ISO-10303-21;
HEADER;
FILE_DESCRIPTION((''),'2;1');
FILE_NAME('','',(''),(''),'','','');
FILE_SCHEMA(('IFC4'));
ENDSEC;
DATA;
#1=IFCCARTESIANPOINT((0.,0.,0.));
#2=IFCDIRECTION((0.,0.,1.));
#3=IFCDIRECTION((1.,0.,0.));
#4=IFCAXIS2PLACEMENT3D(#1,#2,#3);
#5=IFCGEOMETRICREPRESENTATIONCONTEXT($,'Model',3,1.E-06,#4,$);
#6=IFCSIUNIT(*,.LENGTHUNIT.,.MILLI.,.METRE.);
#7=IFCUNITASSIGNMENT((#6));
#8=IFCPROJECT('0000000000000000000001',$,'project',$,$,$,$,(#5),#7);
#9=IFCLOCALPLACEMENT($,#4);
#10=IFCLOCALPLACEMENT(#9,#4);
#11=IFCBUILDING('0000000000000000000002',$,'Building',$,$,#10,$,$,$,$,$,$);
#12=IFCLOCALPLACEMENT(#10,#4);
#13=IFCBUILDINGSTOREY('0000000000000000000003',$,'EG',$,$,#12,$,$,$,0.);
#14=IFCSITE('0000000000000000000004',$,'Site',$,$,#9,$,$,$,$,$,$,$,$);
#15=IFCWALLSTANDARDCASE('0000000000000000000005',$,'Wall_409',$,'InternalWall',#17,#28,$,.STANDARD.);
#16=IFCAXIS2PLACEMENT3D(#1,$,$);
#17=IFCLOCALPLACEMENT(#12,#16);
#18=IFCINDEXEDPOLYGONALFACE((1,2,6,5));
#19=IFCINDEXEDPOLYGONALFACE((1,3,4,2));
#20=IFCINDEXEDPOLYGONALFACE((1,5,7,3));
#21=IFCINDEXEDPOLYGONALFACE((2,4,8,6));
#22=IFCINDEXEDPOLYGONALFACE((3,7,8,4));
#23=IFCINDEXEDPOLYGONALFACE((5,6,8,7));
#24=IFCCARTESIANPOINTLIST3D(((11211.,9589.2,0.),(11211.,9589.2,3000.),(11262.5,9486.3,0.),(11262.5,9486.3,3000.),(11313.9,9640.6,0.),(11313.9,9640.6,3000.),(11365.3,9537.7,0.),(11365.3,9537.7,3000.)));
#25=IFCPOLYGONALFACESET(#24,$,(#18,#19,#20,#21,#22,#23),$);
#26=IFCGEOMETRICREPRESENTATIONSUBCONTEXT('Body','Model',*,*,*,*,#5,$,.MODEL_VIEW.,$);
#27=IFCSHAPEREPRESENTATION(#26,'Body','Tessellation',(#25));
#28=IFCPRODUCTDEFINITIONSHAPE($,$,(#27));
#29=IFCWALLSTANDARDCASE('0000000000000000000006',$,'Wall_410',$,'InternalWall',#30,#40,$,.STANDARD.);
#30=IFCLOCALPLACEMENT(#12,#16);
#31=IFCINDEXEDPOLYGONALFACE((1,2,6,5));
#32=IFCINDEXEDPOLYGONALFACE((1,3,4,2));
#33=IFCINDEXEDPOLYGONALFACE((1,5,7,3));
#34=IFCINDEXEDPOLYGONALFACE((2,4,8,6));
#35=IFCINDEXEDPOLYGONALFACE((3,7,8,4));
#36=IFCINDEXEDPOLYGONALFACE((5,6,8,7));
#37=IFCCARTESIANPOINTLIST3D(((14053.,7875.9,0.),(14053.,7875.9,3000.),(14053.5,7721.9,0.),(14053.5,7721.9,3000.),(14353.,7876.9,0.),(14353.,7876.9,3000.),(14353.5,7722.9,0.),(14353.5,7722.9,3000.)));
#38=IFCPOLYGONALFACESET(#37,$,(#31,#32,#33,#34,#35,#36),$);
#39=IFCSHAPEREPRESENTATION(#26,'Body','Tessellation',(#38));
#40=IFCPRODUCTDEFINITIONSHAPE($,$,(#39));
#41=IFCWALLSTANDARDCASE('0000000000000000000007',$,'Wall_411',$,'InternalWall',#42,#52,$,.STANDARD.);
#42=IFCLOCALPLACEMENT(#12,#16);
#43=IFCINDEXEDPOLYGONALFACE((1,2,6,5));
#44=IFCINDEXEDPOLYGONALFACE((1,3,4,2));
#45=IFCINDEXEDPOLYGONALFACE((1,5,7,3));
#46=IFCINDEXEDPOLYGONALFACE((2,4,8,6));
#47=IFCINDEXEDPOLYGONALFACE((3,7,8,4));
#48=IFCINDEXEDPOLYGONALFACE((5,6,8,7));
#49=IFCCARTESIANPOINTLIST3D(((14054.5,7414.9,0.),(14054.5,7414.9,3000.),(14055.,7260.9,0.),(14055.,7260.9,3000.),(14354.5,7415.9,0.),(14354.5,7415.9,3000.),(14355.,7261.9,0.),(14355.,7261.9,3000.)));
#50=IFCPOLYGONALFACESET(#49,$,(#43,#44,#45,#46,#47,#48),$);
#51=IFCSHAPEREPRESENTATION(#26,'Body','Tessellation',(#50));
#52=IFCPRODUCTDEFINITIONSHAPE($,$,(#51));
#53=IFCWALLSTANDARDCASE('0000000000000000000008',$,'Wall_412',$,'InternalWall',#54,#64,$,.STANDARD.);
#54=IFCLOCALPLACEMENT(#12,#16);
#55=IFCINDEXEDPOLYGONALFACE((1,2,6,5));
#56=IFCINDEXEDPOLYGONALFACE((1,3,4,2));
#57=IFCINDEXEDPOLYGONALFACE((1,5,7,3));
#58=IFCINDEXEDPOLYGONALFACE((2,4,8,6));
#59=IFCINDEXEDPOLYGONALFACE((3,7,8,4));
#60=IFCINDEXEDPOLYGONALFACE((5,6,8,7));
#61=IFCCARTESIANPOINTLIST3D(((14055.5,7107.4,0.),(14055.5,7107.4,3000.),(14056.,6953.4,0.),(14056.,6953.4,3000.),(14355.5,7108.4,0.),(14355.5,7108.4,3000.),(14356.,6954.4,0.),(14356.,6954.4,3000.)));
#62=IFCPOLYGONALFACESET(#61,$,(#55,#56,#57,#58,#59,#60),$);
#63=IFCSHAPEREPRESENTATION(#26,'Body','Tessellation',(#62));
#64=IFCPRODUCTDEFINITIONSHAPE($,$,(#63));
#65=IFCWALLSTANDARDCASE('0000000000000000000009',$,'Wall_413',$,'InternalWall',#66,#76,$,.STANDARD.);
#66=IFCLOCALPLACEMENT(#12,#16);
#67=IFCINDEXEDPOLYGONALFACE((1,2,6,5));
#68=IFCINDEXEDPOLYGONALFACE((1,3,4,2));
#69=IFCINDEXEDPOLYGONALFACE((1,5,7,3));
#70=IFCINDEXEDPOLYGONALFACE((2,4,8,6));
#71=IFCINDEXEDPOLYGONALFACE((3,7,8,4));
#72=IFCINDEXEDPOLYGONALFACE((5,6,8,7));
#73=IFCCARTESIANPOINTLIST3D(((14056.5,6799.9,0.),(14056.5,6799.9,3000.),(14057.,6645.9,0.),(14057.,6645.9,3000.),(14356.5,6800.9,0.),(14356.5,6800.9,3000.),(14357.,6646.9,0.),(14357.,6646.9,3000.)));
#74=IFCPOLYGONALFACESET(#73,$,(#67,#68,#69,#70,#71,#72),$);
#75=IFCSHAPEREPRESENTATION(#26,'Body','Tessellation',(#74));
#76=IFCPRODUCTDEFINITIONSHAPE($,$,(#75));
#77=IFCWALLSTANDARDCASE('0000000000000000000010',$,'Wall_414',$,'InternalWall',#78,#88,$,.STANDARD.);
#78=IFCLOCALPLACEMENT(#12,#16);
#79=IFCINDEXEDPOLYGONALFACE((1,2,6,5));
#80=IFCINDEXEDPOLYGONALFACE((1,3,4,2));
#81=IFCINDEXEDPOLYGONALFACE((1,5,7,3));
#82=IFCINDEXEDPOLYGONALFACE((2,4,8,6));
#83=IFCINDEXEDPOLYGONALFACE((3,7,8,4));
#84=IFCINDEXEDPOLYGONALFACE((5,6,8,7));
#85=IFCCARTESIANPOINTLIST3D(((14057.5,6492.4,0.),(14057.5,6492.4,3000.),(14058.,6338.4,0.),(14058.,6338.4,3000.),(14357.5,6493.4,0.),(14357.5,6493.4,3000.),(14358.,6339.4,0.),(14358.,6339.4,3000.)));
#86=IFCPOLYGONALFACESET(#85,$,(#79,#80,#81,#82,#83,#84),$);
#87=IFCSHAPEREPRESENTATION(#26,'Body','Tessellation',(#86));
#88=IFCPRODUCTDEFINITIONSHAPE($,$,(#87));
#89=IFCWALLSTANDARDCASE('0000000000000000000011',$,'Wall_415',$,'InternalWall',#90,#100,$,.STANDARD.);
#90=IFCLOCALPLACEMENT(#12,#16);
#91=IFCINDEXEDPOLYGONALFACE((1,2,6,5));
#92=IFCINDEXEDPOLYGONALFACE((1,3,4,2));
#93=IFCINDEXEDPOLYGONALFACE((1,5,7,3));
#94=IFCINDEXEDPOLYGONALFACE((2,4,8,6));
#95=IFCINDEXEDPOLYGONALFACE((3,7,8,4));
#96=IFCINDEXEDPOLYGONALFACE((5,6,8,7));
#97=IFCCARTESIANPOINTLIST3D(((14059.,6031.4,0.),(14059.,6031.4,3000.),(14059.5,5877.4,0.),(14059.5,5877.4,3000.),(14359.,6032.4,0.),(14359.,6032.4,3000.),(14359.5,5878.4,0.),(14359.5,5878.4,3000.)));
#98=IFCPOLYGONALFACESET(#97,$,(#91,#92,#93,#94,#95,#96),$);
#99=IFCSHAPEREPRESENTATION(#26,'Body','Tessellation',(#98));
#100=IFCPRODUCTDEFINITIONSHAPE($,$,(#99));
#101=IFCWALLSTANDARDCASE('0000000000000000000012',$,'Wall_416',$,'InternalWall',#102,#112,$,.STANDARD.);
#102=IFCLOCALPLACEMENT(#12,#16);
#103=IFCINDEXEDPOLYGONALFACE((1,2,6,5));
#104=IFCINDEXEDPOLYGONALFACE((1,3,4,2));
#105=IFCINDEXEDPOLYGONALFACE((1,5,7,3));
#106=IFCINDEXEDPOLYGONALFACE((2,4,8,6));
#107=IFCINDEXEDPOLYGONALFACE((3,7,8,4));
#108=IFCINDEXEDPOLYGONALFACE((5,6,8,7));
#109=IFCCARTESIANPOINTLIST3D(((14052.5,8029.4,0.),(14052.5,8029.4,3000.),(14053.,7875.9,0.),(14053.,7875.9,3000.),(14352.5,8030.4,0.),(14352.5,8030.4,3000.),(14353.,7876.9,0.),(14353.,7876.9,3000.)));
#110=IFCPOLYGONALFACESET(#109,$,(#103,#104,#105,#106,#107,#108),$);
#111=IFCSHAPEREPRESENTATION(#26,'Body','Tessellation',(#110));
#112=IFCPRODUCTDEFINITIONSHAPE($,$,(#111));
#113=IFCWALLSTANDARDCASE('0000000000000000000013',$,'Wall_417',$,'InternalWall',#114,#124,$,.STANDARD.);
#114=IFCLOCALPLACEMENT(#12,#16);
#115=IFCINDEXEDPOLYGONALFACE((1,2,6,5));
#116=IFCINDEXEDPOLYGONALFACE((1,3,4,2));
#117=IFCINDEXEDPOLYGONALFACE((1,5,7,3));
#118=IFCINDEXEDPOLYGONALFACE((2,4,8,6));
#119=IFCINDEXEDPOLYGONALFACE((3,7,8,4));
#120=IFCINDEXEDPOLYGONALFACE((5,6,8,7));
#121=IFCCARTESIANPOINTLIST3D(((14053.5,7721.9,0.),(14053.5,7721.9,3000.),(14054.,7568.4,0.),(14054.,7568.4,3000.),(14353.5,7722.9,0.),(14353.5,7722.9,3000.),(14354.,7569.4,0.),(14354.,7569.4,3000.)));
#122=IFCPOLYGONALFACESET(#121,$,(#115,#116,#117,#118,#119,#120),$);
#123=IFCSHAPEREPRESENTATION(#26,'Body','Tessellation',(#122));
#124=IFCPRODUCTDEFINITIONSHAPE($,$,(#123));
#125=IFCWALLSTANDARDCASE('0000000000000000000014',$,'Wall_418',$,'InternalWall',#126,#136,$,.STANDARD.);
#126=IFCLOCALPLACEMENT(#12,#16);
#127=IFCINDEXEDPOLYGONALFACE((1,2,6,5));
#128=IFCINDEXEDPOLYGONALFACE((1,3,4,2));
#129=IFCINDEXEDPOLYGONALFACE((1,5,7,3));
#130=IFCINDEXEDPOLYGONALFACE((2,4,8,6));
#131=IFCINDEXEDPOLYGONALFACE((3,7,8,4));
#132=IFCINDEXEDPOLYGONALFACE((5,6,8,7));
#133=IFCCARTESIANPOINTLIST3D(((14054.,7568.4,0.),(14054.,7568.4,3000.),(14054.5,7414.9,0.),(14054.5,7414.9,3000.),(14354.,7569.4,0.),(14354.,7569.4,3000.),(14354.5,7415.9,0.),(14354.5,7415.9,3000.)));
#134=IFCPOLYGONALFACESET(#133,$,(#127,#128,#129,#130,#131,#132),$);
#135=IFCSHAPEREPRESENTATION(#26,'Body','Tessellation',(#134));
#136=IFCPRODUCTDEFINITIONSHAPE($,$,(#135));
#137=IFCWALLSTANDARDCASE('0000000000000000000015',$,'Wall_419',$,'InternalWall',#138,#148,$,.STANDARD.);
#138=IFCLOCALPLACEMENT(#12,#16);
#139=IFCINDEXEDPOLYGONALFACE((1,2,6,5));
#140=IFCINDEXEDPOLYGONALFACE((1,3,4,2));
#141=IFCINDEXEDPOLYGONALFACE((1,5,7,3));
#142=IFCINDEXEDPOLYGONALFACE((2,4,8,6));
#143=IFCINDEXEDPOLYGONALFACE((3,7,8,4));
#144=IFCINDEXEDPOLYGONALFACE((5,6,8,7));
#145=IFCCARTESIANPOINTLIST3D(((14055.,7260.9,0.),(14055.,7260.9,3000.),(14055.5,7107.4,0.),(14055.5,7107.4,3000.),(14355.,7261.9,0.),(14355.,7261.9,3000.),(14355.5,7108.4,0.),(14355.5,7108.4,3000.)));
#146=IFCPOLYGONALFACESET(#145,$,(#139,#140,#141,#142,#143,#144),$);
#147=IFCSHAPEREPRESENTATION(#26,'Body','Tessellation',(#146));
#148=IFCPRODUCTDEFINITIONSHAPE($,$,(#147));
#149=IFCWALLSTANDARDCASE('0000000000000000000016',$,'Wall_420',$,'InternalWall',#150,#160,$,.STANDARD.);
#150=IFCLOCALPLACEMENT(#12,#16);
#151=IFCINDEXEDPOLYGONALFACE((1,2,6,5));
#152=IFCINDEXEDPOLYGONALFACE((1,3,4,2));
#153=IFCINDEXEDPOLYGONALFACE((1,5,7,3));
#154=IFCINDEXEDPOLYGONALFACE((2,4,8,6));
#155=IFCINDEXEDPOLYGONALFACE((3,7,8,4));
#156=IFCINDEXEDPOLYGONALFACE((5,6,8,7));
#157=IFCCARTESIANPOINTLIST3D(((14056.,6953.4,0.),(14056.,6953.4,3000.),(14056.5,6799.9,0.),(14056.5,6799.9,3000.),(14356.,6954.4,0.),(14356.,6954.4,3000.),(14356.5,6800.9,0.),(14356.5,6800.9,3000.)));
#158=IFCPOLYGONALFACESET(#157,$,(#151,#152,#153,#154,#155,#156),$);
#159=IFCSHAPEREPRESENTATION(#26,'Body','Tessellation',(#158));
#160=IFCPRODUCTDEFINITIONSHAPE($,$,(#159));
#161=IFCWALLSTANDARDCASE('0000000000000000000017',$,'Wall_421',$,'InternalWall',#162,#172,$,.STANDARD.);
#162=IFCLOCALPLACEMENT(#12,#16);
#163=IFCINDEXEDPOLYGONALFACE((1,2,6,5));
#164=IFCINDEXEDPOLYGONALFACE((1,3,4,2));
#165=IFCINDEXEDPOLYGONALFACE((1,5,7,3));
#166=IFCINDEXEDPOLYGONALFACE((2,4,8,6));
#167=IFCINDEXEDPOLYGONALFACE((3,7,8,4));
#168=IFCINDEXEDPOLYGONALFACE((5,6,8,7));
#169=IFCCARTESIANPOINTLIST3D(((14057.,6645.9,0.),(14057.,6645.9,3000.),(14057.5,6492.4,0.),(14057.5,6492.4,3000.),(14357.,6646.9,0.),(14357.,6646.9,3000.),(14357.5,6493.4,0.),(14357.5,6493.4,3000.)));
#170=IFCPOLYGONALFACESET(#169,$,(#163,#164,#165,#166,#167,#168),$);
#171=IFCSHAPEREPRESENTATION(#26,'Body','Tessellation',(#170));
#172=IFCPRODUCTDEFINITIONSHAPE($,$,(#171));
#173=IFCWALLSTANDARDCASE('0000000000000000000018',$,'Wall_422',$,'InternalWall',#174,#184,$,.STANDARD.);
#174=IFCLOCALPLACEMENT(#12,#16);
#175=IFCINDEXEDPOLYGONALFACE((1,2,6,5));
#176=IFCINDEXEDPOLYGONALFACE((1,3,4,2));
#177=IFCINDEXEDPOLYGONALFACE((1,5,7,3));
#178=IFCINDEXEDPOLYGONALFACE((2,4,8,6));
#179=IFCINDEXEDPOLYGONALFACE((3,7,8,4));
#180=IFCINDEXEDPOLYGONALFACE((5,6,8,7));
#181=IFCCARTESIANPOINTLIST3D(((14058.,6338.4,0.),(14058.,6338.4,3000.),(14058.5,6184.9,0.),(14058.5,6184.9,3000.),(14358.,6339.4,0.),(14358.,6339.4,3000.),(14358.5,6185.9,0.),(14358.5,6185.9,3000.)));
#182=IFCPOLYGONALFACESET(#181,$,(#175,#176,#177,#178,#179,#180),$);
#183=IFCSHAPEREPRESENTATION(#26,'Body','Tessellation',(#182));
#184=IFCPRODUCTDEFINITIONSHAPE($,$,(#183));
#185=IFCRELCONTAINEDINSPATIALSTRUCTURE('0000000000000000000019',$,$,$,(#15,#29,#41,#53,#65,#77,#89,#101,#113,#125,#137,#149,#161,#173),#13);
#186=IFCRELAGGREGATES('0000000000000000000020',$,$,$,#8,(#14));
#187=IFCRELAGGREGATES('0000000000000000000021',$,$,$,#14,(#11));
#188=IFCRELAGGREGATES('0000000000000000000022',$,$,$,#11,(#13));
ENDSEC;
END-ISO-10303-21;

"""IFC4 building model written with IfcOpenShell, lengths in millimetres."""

from ifc_helpers import new_model, si_unit, frame, origin_with_axes, place, context, subcontext, project, spatial, rectangle, extrude, element, save


model = new_model("IFC4")

# Units and contexts
model_context = context("Model", 3, precision=1e-06, world=origin_with_axes())
body_context = subcontext(model_context, "Body", "Model", "MODEL_VIEW")
ifc_project = project(units=[si_unit("LENGTHUNIT", "METRE", prefix="MILLI")], contexts=[model_context])

# Site, building, storey
site_placement = place(None, origin_with_axes())
site = spatial("IfcSite", under=ifc_project, at=site_placement, Name="Site")
building_placement = place(site_placement, origin_with_axes())
building = spatial("IfcBuilding", under=site, at=building_placement, Name="Building")
storey_placement = place(building_placement, origin_with_axes())
storey = spatial("IfcBuildingStorey", under=building, at=storey_placement, Name="EG", Elevation=0.0)

# Walls
wall_1_placement = place(storey_placement, origin_with_axes())
element("IfcWallStandardCase", 1, at=wall_1_placement, inside=storey, Name="Wall_409", ObjectType="InternalWall", PredefinedType="STANDARD", context=body_context, shape_type="SweptSolid", body=[
    extrude(rectangle(XDim=115.0, YDim=115.0), frame((11288.2, 9563.4, 0.0), z_axis=(0.0, 0.0, 1.0), x_axis=(-0.447214, 0.894427, 0.0)), (0.0, 0.0, 1.0), 3000.0),
])
wall_2_placement = place(storey_placement, origin_with_axes())
element("IfcWallStandardCase", 2, at=wall_2_placement, inside=storey, Name="Wall_410", ObjectType="InternalWall", PredefinedType="STANDARD", context=body_context, shape_type="SweptSolid", body=[
    extrude(rectangle(XDim=154.0, YDim=300.0), frame((14203.2, 7799.4, 0.0), z_axis=(0.0, 0.0, 1.0), x_axis=(0.003247, -0.999995, 0.0)), (0.0, 0.0, 1.0), 3000.0),
])
wall_3_placement = place(storey_placement, origin_with_axes())
element("IfcWallStandardCase", 3, at=wall_3_placement, inside=storey, Name="Wall_411", ObjectType="InternalWall", PredefinedType="STANDARD", context=body_context, shape_type="SweptSolid", body=[
    extrude(rectangle(XDim=154.0, YDim=300.0), frame((14204.7, 7338.4, 0.0), z_axis=(0.0, 0.0, 1.0), x_axis=(0.003247, -0.999995, 0.0)), (0.0, 0.0, 1.0), 3000.0),
])
wall_4_placement = place(storey_placement, origin_with_axes())
element("IfcWallStandardCase", 4, at=wall_4_placement, inside=storey, Name="Wall_412", ObjectType="InternalWall", PredefinedType="STANDARD", context=body_context, shape_type="SweptSolid", body=[
    extrude(rectangle(XDim=154.0, YDim=300.0), frame((14205.7, 7030.9, 0.0), z_axis=(0.0, 0.0, 1.0), x_axis=(0.003247, -0.999995, 0.0)), (0.0, 0.0, 1.0), 3000.0),
])
wall_5_placement = place(storey_placement, origin_with_axes())
element("IfcWallStandardCase", 5, at=wall_5_placement, inside=storey, Name="Wall_413", ObjectType="InternalWall", PredefinedType="STANDARD", context=body_context, shape_type="SweptSolid", body=[
    extrude(rectangle(XDim=154.0, YDim=300.0), frame((14206.7, 6723.4, 0.0), z_axis=(0.0, 0.0, 1.0), x_axis=(0.003247, -0.999995, 0.0)), (0.0, 0.0, 1.0), 3000.0),
])
wall_6_placement = place(storey_placement, origin_with_axes())
element("IfcWallStandardCase", 6, at=wall_6_placement, inside=storey, Name="Wall_414", ObjectType="InternalWall", PredefinedType="STANDARD", context=body_context, shape_type="SweptSolid", body=[
    extrude(rectangle(XDim=154.0, YDim=300.0), frame((14207.7, 6415.9, 0.0), z_axis=(0.0, 0.0, 1.0), x_axis=(0.003247, -0.999995, 0.0)), (0.0, 0.0, 1.0), 3000.0),
])
wall_7_placement = place(storey_placement, origin_with_axes())
element("IfcWallStandardCase", 7, at=wall_7_placement, inside=storey, Name="Wall_415", ObjectType="InternalWall", PredefinedType="STANDARD", context=body_context, shape_type="SweptSolid", body=[
    extrude(rectangle(XDim=154.0, YDim=300.0), frame((14209.2, 5954.9, 0.0), z_axis=(0.0, 0.0, 1.0), x_axis=(0.003247, -0.999995, 0.0)), (0.0, 0.0, 1.0), 3000.0),
])
wall_8_placement = place(storey_placement, origin_with_axes())
element("IfcWallStandardCase", 8, at=wall_8_placement, inside=storey, Name="Wall_416", ObjectType="InternalWall", PredefinedType="STANDARD", context=body_context, shape_type="SweptSolid", body=[
    extrude(rectangle(XDim=153.5, YDim=300.0), frame((14202.7, 7953.1, 0.0), z_axis=(0.0, 0.0, 1.0), x_axis=(-0.003257, 0.999995, 0.0)), (0.0, 0.0, 1.0), 3000.0),
])
wall_9_placement = place(storey_placement, origin_with_axes())
element("IfcWallStandardCase", 9, at=wall_9_placement, inside=storey, Name="Wall_417", ObjectType="InternalWall", PredefinedType="STANDARD", context=body_context, shape_type="SweptSolid", body=[
    extrude(rectangle(XDim=153.5, YDim=300.0), frame((14203.7, 7645.6, 0.0), z_axis=(0.0, 0.0, 1.0), x_axis=(0.003257, -0.999995, 0.0)), (0.0, 0.0, 1.0), 3000.0),
])
wall_10_placement = place(storey_placement, origin_with_axes())
element("IfcWallStandardCase", 10, at=wall_10_placement, inside=storey, Name="Wall_418", ObjectType="InternalWall", PredefinedType="STANDARD", context=body_context, shape_type="SweptSolid", body=[
    extrude(rectangle(XDim=153.5, YDim=300.0), frame((14204.2, 7492.1, 0.0), z_axis=(0.0, 0.0, 1.0), x_axis=(0.003257, -0.999995, 0.0)), (0.0, 0.0, 1.0), 3000.0),
])
wall_11_placement = place(storey_placement, origin_with_axes())
element("IfcWallStandardCase", 11, at=wall_11_placement, inside=storey, Name="Wall_419", ObjectType="InternalWall", PredefinedType="STANDARD", context=body_context, shape_type="SweptSolid", body=[
    extrude(rectangle(XDim=153.5, YDim=300.0), frame((14205.2, 7184.6, 0.0), z_axis=(0.0, 0.0, 1.0), x_axis=(0.003257, -0.999995, 0.0)), (0.0, 0.0, 1.0), 3000.0),
])
wall_12_placement = place(storey_placement, origin_with_axes())
element("IfcWallStandardCase", 12, at=wall_12_placement, inside=storey, Name="Wall_420", ObjectType="InternalWall", PredefinedType="STANDARD", context=body_context, shape_type="SweptSolid", body=[
    extrude(rectangle(XDim=153.5, YDim=300.0), frame((14206.2, 6877.1, 0.0), z_axis=(0.0, 0.0, 1.0), x_axis=(0.003257, -0.999995, 0.0)), (0.0, 0.0, 1.0), 3000.0),
])
wall_13_placement = place(storey_placement, origin_with_axes())
element("IfcWallStandardCase", 13, at=wall_13_placement, inside=storey, Name="Wall_421", ObjectType="InternalWall", PredefinedType="STANDARD", context=body_context, shape_type="SweptSolid", body=[
    extrude(rectangle(XDim=153.5, YDim=300.0), frame((14207.2, 6569.6, 0.0), z_axis=(0.0, 0.0, 1.0), x_axis=(0.003257, -0.999995, 0.0)), (0.0, 0.0, 1.0), 3000.0),
])
wall_14_placement = place(storey_placement, origin_with_axes())
element("IfcWallStandardCase", 14, at=wall_14_placement, inside=storey, Name="Wall_422", ObjectType="InternalWall", PredefinedType="STANDARD", context=body_context, shape_type="SweptSolid", body=[
    extrude(rectangle(XDim=153.5, YDim=300.0), frame((14208.2, 6262.1, 0.0), z_axis=(0.0, 0.0, 1.0), x_axis=(0.003257, -0.999995, 0.0)), (0.0, 0.0, 1.0), 3000.0),
])

save(model, "model.ifc")
